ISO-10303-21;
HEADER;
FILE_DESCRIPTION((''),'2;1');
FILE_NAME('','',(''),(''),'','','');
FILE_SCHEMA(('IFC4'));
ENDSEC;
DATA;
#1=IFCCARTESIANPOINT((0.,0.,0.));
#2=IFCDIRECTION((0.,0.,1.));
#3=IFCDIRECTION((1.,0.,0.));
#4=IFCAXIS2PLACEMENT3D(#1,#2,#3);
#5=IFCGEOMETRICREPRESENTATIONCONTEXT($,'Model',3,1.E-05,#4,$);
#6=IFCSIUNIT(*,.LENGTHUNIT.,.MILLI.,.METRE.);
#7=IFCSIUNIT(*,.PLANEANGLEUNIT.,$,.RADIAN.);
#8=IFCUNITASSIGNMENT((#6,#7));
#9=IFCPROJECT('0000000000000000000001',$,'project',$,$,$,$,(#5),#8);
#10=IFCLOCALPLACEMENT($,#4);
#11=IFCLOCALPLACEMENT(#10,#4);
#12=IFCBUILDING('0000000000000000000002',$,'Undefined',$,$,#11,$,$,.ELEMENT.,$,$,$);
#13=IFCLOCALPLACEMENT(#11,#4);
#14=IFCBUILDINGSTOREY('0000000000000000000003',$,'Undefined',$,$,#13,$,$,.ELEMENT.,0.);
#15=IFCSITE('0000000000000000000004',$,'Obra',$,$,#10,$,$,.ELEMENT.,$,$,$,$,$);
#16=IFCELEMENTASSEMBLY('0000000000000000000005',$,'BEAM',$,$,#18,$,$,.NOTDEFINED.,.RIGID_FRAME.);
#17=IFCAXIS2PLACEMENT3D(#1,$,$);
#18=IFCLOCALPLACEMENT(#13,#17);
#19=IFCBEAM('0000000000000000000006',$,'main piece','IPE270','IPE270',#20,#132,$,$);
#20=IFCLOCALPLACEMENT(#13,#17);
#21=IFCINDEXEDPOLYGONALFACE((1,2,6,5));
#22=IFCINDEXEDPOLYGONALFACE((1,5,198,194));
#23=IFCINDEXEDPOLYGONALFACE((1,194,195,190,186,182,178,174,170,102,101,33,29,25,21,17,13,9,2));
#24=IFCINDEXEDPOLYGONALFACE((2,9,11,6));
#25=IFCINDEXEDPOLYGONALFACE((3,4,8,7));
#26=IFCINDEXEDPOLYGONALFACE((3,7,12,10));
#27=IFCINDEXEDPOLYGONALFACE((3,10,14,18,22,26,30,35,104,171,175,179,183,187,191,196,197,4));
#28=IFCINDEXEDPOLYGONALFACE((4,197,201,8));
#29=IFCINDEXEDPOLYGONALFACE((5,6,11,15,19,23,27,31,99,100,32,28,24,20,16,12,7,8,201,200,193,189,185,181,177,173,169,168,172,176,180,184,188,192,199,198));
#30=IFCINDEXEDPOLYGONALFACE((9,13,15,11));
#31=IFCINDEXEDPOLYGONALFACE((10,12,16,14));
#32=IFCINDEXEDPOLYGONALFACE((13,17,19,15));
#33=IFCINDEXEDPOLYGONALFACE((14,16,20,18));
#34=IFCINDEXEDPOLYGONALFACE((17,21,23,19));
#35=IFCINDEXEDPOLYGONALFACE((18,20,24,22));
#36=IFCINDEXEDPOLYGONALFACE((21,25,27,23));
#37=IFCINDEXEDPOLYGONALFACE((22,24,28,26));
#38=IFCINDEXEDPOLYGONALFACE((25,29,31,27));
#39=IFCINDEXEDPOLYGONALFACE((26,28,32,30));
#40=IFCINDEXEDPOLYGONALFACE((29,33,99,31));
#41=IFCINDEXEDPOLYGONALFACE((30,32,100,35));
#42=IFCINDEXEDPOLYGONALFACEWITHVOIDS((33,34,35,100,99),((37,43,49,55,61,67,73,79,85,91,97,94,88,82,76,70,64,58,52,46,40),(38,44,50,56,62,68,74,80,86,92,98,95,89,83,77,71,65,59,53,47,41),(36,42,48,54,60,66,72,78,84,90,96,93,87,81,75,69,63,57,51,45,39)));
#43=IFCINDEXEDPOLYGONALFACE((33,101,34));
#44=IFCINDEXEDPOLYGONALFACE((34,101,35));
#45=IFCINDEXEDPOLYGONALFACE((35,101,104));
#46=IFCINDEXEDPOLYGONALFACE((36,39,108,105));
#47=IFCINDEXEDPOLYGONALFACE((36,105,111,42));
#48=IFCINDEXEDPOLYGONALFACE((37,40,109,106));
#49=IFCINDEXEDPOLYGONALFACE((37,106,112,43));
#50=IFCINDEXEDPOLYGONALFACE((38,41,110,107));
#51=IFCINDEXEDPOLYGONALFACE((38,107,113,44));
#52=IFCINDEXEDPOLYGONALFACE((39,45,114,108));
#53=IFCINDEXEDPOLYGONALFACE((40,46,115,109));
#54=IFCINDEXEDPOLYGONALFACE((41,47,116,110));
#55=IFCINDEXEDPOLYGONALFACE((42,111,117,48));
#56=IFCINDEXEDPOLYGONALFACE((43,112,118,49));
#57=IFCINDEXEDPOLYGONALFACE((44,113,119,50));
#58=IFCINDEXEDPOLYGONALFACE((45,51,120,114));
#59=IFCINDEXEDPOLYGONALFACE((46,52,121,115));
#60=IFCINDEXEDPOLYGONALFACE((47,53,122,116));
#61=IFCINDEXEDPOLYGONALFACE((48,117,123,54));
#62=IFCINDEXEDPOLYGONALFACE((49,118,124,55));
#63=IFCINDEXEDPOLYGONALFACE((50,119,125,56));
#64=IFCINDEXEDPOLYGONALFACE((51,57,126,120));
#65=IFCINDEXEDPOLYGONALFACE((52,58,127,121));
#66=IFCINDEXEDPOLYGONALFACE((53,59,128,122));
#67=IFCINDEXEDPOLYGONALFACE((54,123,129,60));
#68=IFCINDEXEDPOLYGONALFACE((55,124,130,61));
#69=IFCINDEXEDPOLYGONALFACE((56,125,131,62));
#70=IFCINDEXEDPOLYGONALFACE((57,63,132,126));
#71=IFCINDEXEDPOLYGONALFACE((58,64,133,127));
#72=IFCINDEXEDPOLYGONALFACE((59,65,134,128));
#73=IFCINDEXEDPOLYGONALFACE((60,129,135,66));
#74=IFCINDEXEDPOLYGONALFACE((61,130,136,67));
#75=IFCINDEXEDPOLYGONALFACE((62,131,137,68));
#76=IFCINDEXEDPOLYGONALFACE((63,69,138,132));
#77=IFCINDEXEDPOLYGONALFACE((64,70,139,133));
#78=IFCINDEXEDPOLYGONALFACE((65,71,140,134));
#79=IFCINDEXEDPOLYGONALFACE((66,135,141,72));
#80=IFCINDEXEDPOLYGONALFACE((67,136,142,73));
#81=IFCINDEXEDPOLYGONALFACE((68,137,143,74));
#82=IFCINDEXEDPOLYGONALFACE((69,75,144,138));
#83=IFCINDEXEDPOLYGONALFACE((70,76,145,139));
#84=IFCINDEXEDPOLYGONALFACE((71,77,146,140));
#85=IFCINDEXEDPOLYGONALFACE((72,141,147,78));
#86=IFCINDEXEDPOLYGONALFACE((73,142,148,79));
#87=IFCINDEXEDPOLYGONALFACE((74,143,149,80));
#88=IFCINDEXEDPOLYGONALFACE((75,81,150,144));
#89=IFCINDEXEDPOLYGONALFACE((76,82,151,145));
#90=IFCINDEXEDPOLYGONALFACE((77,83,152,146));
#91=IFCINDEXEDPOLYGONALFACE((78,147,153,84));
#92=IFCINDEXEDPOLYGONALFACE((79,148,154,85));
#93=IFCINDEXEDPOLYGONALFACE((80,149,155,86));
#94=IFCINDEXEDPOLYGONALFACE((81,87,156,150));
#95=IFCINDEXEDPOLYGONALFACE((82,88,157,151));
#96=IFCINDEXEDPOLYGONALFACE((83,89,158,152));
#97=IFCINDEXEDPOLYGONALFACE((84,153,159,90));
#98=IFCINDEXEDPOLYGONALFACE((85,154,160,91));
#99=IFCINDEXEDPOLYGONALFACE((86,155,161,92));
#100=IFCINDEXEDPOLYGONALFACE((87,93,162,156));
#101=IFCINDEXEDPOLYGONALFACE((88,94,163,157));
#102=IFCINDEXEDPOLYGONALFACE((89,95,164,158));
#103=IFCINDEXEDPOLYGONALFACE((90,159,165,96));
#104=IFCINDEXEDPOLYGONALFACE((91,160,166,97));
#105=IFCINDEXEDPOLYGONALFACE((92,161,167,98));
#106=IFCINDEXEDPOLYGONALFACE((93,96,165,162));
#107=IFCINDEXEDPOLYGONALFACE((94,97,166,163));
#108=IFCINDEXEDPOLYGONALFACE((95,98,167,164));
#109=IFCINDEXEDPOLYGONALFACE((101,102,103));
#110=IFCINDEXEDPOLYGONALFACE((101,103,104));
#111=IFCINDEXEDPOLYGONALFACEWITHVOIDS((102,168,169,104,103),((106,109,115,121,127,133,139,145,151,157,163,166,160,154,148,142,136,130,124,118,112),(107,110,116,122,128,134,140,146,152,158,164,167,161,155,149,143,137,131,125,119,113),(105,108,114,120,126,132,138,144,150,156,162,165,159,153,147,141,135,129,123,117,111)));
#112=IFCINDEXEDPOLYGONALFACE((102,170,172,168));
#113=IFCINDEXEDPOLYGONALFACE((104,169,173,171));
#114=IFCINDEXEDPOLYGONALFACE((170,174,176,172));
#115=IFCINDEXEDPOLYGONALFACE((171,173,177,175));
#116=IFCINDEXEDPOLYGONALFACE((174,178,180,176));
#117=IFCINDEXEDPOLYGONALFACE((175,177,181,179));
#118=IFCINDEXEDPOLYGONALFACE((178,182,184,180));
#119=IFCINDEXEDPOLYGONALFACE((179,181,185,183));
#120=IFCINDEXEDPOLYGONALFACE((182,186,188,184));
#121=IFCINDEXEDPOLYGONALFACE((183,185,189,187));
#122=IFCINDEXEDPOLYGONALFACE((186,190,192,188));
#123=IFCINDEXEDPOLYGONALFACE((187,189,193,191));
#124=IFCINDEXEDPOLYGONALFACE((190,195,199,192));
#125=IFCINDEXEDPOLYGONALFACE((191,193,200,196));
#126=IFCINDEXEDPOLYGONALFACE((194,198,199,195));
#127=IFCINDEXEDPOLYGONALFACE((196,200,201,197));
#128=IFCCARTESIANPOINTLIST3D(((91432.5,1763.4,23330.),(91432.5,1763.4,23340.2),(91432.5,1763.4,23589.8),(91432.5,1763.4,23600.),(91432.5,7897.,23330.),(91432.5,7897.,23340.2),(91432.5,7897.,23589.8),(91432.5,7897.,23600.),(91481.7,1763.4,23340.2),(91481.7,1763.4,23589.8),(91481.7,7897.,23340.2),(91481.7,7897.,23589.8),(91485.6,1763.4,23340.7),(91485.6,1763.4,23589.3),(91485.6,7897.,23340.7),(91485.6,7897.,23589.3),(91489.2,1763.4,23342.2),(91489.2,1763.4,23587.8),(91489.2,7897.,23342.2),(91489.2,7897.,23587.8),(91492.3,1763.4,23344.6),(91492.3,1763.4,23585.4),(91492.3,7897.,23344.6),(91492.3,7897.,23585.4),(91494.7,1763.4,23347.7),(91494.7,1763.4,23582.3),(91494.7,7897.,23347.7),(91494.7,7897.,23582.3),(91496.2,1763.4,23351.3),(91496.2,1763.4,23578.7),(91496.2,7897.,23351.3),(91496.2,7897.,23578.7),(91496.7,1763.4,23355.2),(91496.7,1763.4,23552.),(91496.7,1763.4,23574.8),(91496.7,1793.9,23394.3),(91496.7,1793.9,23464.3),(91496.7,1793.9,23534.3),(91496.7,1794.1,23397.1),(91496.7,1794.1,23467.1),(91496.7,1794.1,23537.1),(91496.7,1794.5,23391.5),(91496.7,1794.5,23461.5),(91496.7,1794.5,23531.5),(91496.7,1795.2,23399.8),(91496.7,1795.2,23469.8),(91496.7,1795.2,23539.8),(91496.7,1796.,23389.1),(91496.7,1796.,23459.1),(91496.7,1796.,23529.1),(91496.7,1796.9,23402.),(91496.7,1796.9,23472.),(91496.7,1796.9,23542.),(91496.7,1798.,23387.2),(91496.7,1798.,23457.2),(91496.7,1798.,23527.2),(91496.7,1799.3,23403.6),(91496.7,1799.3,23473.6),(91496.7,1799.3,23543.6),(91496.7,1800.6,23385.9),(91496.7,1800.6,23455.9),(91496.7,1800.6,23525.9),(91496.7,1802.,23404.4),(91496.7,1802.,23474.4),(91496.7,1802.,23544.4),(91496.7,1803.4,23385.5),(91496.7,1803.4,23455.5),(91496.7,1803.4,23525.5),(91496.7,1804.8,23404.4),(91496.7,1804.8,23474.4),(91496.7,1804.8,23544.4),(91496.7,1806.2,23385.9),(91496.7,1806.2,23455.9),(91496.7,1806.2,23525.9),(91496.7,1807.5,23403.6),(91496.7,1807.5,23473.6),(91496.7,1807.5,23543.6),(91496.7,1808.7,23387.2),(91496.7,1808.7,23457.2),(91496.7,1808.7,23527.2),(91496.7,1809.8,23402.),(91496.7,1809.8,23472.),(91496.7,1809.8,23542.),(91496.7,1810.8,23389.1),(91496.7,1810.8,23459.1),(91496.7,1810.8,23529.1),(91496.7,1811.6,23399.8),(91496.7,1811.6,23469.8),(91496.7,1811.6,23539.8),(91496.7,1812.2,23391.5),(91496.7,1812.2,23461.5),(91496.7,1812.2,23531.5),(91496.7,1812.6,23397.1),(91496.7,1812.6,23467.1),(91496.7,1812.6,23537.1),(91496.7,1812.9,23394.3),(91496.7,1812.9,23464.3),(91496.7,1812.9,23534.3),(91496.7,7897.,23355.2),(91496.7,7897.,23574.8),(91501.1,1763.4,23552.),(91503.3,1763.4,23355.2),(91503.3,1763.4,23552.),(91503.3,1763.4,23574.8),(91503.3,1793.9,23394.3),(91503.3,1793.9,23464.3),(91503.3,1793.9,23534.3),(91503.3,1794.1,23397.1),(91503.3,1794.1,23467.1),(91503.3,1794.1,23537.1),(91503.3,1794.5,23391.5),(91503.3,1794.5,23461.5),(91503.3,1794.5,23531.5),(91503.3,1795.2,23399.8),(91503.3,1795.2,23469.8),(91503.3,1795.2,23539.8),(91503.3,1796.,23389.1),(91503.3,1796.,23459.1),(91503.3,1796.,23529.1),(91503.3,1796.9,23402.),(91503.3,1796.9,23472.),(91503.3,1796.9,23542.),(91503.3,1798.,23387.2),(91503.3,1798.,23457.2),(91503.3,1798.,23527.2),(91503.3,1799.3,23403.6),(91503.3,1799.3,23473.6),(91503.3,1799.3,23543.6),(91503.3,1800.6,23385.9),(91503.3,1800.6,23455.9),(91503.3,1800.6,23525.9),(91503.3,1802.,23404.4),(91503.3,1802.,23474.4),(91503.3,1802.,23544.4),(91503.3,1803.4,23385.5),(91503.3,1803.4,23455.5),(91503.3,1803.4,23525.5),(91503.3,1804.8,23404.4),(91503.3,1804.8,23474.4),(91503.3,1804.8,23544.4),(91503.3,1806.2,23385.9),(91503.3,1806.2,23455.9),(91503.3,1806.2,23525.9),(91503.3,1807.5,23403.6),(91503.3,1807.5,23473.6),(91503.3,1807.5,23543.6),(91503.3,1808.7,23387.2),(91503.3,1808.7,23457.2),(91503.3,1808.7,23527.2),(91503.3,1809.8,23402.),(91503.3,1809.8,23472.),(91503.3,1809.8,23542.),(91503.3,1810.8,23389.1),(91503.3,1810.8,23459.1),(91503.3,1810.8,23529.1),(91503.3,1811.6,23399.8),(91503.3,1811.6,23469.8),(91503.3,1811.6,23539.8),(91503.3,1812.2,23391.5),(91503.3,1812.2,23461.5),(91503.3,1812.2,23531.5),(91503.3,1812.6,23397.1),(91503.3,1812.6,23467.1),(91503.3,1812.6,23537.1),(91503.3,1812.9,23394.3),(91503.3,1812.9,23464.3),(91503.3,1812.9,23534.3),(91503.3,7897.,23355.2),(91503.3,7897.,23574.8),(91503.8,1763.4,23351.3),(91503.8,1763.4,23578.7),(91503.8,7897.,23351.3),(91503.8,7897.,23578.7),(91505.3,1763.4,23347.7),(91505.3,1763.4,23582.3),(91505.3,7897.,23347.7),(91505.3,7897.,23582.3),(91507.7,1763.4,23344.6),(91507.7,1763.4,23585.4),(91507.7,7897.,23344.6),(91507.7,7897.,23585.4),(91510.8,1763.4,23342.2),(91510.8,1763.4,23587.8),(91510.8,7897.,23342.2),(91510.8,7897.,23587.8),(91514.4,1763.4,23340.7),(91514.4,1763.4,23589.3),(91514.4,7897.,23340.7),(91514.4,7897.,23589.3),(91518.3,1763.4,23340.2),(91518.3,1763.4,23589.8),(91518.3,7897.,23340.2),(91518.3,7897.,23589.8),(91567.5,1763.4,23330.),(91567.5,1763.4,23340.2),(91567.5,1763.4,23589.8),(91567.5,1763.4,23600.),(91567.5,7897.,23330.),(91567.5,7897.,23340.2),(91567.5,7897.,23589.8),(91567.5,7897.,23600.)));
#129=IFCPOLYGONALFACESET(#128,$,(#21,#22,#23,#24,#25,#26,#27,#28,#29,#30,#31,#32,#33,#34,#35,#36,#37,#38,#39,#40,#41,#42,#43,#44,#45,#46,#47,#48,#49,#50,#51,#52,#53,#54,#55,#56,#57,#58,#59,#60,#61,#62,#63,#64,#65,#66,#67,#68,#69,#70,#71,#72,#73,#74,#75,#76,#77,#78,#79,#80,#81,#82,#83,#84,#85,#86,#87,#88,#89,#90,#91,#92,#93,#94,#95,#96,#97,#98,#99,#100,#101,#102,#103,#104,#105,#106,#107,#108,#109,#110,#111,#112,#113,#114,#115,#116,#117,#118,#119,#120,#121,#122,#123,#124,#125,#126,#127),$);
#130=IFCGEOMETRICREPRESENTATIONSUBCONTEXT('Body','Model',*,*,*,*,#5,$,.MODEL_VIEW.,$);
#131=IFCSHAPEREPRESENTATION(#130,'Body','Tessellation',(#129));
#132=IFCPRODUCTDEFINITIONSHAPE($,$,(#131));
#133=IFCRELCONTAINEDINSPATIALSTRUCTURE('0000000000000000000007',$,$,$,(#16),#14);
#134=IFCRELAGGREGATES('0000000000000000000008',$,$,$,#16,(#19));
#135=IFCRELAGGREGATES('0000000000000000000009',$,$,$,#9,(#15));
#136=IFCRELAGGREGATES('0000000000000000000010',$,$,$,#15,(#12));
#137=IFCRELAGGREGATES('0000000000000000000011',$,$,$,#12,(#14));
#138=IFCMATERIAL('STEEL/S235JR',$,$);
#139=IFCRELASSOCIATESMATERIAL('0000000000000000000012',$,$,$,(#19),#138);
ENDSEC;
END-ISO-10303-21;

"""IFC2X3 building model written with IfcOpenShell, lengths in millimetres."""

from ifc_helpers import new_model, si_unit, frame, origin_with_axes, origin_2d_with_axis, place, context, subcontext, project, spatial, rectangle, circle, i_section, extrude, clip, halfspace, source, transform, mapped, material, element, aggregate, save


model = new_model("IFC2X3")

# Units and contexts
model_context = context("Model", 3, precision=1e-05, world=origin_with_axes())
body_context = subcontext(model_context, "Body", "Model", "MODEL_VIEW")
ifc_project = project(units=[si_unit("LENGTHUNIT", "METRE", prefix="MILLI"), si_unit("PLANEANGLEUNIT", "RADIAN")], contexts=[model_context])

# Site, building, storey
site_placement = place(None, origin_with_axes())
site = spatial("IfcSite", under=ifc_project, at=site_placement, Name="Obra", CompositionType="ELEMENT")
building_placement = place(site_placement, origin_with_axes())
building = spatial("IfcBuilding", under=site, at=building_placement, Name="Undefined", CompositionType="ELEMENT")
storey_placement = place(building_placement, origin_with_axes())
storey = spatial("IfcBuildingStorey", under=building, at=storey_placement, Name="Undefined", CompositionType="ELEMENT", Elevation=0.0)

# Shared definitions
ifc_material_1 = material(Name="STEEL/S235JR")

# Element assembly, beam, openings
assembly_1_placement = place(storey_placement, origin_with_axes())
assembly_1 = element("IfcElementAssembly", 1, at=assembly_1_placement, inside=storey, Name="BEAM", AssemblyPlace="NOTDEFINED", PredefinedType="RIGID_FRAME")
beam_1_placement = place(assembly_1_placement, frame((91500.0, 1766.1, 23465.0), z_axis=(0.0, 0.0, 1.0), x_axis=(0.000001, 1.0, 0.0)))
beam_1 = element("IfcBeam", 2, at=beam_1_placement, material=ifc_material_1, Name="main piece", Description="IPE270", ObjectType="IPE270", context=body_context, shape_type="Clipping", body=[
    clip(extrude(i_section(OverallWidth=135.0, OverallDepth=270.0, WebThickness=6.6, FlangeThickness=10.2, FilletRadius=15.0, at=origin_2d_with_axis()), frame((6130.9, 0.0, 0.0), z_axis=(-1.0, 0.0, 0.0), x_axis=(0.0, -1.0, 0.0)), (0.0, 0.0, 1.0), 6133.6), halfspace(frame((-2.7, 0.0, -235.0), z_axis=(1.0, 0.000002, 0.0), x_axis=(0.000002, -1.0, 0.0)), True)),
])
opening_1_placement = place(assembly_1_placement, frame((91500.0, 1766.1, 23465.0), z_axis=(0.0, 0.0, 1.0), x_axis=(0.000001, 1.0, 0.0)))
element("IfcOpeningElement", 3, at=opening_1_placement, cuts=beam_1, ObjectType="Recess", context=body_context, shape_type="SweptSolid", body=[
    extrude(rectangle(XDim=49.0, YDim=156.3, at=origin_2d_with_axis()), frame((-80.8, -68.5, 111.5), z_axis=(-0.000002, 1.0, 0.0), x_axis=(0.0, 0.0, -1.0)), (0.0, 0.0, 1.0), 137.0),
])
shared_shape_1 = source(origin_with_axes(), body_context, "Body", "SweptSolid", [
    extrude(circle(Radius=9.5, at=origin_2d_with_axis()), frame((0.0, -3.4, 0.0), z_axis=(0.0, 1.0, 0.0), x_axis=(1.0, 0.0, 0.0)), (0.0, 0.0, 1.0), 6.8),
])
opening_2_placement = place(assembly_1_placement, frame((91500.0, 1763.4, 23570.0), z_axis=(0.0, 1.0, 0.0), x_axis=(0.0, 0.0, -1.0)))
element("IfcOpeningElement", 4, at=opening_2_placement, cuts=beam_1, ObjectType="Opening", context=body_context, shape_type="MappedRepresentation", body=[
    mapped(shared_shape_1, transform((35.0, 0.0, 40.0))),
    mapped(shared_shape_1, transform((105.0, 0.0, 40.0))),
    mapped(shared_shape_1, transform((175.0, 0.0, 40.0))),
])

aggregate(assembly_1, [beam_1])

save(model, "model.ifc")
